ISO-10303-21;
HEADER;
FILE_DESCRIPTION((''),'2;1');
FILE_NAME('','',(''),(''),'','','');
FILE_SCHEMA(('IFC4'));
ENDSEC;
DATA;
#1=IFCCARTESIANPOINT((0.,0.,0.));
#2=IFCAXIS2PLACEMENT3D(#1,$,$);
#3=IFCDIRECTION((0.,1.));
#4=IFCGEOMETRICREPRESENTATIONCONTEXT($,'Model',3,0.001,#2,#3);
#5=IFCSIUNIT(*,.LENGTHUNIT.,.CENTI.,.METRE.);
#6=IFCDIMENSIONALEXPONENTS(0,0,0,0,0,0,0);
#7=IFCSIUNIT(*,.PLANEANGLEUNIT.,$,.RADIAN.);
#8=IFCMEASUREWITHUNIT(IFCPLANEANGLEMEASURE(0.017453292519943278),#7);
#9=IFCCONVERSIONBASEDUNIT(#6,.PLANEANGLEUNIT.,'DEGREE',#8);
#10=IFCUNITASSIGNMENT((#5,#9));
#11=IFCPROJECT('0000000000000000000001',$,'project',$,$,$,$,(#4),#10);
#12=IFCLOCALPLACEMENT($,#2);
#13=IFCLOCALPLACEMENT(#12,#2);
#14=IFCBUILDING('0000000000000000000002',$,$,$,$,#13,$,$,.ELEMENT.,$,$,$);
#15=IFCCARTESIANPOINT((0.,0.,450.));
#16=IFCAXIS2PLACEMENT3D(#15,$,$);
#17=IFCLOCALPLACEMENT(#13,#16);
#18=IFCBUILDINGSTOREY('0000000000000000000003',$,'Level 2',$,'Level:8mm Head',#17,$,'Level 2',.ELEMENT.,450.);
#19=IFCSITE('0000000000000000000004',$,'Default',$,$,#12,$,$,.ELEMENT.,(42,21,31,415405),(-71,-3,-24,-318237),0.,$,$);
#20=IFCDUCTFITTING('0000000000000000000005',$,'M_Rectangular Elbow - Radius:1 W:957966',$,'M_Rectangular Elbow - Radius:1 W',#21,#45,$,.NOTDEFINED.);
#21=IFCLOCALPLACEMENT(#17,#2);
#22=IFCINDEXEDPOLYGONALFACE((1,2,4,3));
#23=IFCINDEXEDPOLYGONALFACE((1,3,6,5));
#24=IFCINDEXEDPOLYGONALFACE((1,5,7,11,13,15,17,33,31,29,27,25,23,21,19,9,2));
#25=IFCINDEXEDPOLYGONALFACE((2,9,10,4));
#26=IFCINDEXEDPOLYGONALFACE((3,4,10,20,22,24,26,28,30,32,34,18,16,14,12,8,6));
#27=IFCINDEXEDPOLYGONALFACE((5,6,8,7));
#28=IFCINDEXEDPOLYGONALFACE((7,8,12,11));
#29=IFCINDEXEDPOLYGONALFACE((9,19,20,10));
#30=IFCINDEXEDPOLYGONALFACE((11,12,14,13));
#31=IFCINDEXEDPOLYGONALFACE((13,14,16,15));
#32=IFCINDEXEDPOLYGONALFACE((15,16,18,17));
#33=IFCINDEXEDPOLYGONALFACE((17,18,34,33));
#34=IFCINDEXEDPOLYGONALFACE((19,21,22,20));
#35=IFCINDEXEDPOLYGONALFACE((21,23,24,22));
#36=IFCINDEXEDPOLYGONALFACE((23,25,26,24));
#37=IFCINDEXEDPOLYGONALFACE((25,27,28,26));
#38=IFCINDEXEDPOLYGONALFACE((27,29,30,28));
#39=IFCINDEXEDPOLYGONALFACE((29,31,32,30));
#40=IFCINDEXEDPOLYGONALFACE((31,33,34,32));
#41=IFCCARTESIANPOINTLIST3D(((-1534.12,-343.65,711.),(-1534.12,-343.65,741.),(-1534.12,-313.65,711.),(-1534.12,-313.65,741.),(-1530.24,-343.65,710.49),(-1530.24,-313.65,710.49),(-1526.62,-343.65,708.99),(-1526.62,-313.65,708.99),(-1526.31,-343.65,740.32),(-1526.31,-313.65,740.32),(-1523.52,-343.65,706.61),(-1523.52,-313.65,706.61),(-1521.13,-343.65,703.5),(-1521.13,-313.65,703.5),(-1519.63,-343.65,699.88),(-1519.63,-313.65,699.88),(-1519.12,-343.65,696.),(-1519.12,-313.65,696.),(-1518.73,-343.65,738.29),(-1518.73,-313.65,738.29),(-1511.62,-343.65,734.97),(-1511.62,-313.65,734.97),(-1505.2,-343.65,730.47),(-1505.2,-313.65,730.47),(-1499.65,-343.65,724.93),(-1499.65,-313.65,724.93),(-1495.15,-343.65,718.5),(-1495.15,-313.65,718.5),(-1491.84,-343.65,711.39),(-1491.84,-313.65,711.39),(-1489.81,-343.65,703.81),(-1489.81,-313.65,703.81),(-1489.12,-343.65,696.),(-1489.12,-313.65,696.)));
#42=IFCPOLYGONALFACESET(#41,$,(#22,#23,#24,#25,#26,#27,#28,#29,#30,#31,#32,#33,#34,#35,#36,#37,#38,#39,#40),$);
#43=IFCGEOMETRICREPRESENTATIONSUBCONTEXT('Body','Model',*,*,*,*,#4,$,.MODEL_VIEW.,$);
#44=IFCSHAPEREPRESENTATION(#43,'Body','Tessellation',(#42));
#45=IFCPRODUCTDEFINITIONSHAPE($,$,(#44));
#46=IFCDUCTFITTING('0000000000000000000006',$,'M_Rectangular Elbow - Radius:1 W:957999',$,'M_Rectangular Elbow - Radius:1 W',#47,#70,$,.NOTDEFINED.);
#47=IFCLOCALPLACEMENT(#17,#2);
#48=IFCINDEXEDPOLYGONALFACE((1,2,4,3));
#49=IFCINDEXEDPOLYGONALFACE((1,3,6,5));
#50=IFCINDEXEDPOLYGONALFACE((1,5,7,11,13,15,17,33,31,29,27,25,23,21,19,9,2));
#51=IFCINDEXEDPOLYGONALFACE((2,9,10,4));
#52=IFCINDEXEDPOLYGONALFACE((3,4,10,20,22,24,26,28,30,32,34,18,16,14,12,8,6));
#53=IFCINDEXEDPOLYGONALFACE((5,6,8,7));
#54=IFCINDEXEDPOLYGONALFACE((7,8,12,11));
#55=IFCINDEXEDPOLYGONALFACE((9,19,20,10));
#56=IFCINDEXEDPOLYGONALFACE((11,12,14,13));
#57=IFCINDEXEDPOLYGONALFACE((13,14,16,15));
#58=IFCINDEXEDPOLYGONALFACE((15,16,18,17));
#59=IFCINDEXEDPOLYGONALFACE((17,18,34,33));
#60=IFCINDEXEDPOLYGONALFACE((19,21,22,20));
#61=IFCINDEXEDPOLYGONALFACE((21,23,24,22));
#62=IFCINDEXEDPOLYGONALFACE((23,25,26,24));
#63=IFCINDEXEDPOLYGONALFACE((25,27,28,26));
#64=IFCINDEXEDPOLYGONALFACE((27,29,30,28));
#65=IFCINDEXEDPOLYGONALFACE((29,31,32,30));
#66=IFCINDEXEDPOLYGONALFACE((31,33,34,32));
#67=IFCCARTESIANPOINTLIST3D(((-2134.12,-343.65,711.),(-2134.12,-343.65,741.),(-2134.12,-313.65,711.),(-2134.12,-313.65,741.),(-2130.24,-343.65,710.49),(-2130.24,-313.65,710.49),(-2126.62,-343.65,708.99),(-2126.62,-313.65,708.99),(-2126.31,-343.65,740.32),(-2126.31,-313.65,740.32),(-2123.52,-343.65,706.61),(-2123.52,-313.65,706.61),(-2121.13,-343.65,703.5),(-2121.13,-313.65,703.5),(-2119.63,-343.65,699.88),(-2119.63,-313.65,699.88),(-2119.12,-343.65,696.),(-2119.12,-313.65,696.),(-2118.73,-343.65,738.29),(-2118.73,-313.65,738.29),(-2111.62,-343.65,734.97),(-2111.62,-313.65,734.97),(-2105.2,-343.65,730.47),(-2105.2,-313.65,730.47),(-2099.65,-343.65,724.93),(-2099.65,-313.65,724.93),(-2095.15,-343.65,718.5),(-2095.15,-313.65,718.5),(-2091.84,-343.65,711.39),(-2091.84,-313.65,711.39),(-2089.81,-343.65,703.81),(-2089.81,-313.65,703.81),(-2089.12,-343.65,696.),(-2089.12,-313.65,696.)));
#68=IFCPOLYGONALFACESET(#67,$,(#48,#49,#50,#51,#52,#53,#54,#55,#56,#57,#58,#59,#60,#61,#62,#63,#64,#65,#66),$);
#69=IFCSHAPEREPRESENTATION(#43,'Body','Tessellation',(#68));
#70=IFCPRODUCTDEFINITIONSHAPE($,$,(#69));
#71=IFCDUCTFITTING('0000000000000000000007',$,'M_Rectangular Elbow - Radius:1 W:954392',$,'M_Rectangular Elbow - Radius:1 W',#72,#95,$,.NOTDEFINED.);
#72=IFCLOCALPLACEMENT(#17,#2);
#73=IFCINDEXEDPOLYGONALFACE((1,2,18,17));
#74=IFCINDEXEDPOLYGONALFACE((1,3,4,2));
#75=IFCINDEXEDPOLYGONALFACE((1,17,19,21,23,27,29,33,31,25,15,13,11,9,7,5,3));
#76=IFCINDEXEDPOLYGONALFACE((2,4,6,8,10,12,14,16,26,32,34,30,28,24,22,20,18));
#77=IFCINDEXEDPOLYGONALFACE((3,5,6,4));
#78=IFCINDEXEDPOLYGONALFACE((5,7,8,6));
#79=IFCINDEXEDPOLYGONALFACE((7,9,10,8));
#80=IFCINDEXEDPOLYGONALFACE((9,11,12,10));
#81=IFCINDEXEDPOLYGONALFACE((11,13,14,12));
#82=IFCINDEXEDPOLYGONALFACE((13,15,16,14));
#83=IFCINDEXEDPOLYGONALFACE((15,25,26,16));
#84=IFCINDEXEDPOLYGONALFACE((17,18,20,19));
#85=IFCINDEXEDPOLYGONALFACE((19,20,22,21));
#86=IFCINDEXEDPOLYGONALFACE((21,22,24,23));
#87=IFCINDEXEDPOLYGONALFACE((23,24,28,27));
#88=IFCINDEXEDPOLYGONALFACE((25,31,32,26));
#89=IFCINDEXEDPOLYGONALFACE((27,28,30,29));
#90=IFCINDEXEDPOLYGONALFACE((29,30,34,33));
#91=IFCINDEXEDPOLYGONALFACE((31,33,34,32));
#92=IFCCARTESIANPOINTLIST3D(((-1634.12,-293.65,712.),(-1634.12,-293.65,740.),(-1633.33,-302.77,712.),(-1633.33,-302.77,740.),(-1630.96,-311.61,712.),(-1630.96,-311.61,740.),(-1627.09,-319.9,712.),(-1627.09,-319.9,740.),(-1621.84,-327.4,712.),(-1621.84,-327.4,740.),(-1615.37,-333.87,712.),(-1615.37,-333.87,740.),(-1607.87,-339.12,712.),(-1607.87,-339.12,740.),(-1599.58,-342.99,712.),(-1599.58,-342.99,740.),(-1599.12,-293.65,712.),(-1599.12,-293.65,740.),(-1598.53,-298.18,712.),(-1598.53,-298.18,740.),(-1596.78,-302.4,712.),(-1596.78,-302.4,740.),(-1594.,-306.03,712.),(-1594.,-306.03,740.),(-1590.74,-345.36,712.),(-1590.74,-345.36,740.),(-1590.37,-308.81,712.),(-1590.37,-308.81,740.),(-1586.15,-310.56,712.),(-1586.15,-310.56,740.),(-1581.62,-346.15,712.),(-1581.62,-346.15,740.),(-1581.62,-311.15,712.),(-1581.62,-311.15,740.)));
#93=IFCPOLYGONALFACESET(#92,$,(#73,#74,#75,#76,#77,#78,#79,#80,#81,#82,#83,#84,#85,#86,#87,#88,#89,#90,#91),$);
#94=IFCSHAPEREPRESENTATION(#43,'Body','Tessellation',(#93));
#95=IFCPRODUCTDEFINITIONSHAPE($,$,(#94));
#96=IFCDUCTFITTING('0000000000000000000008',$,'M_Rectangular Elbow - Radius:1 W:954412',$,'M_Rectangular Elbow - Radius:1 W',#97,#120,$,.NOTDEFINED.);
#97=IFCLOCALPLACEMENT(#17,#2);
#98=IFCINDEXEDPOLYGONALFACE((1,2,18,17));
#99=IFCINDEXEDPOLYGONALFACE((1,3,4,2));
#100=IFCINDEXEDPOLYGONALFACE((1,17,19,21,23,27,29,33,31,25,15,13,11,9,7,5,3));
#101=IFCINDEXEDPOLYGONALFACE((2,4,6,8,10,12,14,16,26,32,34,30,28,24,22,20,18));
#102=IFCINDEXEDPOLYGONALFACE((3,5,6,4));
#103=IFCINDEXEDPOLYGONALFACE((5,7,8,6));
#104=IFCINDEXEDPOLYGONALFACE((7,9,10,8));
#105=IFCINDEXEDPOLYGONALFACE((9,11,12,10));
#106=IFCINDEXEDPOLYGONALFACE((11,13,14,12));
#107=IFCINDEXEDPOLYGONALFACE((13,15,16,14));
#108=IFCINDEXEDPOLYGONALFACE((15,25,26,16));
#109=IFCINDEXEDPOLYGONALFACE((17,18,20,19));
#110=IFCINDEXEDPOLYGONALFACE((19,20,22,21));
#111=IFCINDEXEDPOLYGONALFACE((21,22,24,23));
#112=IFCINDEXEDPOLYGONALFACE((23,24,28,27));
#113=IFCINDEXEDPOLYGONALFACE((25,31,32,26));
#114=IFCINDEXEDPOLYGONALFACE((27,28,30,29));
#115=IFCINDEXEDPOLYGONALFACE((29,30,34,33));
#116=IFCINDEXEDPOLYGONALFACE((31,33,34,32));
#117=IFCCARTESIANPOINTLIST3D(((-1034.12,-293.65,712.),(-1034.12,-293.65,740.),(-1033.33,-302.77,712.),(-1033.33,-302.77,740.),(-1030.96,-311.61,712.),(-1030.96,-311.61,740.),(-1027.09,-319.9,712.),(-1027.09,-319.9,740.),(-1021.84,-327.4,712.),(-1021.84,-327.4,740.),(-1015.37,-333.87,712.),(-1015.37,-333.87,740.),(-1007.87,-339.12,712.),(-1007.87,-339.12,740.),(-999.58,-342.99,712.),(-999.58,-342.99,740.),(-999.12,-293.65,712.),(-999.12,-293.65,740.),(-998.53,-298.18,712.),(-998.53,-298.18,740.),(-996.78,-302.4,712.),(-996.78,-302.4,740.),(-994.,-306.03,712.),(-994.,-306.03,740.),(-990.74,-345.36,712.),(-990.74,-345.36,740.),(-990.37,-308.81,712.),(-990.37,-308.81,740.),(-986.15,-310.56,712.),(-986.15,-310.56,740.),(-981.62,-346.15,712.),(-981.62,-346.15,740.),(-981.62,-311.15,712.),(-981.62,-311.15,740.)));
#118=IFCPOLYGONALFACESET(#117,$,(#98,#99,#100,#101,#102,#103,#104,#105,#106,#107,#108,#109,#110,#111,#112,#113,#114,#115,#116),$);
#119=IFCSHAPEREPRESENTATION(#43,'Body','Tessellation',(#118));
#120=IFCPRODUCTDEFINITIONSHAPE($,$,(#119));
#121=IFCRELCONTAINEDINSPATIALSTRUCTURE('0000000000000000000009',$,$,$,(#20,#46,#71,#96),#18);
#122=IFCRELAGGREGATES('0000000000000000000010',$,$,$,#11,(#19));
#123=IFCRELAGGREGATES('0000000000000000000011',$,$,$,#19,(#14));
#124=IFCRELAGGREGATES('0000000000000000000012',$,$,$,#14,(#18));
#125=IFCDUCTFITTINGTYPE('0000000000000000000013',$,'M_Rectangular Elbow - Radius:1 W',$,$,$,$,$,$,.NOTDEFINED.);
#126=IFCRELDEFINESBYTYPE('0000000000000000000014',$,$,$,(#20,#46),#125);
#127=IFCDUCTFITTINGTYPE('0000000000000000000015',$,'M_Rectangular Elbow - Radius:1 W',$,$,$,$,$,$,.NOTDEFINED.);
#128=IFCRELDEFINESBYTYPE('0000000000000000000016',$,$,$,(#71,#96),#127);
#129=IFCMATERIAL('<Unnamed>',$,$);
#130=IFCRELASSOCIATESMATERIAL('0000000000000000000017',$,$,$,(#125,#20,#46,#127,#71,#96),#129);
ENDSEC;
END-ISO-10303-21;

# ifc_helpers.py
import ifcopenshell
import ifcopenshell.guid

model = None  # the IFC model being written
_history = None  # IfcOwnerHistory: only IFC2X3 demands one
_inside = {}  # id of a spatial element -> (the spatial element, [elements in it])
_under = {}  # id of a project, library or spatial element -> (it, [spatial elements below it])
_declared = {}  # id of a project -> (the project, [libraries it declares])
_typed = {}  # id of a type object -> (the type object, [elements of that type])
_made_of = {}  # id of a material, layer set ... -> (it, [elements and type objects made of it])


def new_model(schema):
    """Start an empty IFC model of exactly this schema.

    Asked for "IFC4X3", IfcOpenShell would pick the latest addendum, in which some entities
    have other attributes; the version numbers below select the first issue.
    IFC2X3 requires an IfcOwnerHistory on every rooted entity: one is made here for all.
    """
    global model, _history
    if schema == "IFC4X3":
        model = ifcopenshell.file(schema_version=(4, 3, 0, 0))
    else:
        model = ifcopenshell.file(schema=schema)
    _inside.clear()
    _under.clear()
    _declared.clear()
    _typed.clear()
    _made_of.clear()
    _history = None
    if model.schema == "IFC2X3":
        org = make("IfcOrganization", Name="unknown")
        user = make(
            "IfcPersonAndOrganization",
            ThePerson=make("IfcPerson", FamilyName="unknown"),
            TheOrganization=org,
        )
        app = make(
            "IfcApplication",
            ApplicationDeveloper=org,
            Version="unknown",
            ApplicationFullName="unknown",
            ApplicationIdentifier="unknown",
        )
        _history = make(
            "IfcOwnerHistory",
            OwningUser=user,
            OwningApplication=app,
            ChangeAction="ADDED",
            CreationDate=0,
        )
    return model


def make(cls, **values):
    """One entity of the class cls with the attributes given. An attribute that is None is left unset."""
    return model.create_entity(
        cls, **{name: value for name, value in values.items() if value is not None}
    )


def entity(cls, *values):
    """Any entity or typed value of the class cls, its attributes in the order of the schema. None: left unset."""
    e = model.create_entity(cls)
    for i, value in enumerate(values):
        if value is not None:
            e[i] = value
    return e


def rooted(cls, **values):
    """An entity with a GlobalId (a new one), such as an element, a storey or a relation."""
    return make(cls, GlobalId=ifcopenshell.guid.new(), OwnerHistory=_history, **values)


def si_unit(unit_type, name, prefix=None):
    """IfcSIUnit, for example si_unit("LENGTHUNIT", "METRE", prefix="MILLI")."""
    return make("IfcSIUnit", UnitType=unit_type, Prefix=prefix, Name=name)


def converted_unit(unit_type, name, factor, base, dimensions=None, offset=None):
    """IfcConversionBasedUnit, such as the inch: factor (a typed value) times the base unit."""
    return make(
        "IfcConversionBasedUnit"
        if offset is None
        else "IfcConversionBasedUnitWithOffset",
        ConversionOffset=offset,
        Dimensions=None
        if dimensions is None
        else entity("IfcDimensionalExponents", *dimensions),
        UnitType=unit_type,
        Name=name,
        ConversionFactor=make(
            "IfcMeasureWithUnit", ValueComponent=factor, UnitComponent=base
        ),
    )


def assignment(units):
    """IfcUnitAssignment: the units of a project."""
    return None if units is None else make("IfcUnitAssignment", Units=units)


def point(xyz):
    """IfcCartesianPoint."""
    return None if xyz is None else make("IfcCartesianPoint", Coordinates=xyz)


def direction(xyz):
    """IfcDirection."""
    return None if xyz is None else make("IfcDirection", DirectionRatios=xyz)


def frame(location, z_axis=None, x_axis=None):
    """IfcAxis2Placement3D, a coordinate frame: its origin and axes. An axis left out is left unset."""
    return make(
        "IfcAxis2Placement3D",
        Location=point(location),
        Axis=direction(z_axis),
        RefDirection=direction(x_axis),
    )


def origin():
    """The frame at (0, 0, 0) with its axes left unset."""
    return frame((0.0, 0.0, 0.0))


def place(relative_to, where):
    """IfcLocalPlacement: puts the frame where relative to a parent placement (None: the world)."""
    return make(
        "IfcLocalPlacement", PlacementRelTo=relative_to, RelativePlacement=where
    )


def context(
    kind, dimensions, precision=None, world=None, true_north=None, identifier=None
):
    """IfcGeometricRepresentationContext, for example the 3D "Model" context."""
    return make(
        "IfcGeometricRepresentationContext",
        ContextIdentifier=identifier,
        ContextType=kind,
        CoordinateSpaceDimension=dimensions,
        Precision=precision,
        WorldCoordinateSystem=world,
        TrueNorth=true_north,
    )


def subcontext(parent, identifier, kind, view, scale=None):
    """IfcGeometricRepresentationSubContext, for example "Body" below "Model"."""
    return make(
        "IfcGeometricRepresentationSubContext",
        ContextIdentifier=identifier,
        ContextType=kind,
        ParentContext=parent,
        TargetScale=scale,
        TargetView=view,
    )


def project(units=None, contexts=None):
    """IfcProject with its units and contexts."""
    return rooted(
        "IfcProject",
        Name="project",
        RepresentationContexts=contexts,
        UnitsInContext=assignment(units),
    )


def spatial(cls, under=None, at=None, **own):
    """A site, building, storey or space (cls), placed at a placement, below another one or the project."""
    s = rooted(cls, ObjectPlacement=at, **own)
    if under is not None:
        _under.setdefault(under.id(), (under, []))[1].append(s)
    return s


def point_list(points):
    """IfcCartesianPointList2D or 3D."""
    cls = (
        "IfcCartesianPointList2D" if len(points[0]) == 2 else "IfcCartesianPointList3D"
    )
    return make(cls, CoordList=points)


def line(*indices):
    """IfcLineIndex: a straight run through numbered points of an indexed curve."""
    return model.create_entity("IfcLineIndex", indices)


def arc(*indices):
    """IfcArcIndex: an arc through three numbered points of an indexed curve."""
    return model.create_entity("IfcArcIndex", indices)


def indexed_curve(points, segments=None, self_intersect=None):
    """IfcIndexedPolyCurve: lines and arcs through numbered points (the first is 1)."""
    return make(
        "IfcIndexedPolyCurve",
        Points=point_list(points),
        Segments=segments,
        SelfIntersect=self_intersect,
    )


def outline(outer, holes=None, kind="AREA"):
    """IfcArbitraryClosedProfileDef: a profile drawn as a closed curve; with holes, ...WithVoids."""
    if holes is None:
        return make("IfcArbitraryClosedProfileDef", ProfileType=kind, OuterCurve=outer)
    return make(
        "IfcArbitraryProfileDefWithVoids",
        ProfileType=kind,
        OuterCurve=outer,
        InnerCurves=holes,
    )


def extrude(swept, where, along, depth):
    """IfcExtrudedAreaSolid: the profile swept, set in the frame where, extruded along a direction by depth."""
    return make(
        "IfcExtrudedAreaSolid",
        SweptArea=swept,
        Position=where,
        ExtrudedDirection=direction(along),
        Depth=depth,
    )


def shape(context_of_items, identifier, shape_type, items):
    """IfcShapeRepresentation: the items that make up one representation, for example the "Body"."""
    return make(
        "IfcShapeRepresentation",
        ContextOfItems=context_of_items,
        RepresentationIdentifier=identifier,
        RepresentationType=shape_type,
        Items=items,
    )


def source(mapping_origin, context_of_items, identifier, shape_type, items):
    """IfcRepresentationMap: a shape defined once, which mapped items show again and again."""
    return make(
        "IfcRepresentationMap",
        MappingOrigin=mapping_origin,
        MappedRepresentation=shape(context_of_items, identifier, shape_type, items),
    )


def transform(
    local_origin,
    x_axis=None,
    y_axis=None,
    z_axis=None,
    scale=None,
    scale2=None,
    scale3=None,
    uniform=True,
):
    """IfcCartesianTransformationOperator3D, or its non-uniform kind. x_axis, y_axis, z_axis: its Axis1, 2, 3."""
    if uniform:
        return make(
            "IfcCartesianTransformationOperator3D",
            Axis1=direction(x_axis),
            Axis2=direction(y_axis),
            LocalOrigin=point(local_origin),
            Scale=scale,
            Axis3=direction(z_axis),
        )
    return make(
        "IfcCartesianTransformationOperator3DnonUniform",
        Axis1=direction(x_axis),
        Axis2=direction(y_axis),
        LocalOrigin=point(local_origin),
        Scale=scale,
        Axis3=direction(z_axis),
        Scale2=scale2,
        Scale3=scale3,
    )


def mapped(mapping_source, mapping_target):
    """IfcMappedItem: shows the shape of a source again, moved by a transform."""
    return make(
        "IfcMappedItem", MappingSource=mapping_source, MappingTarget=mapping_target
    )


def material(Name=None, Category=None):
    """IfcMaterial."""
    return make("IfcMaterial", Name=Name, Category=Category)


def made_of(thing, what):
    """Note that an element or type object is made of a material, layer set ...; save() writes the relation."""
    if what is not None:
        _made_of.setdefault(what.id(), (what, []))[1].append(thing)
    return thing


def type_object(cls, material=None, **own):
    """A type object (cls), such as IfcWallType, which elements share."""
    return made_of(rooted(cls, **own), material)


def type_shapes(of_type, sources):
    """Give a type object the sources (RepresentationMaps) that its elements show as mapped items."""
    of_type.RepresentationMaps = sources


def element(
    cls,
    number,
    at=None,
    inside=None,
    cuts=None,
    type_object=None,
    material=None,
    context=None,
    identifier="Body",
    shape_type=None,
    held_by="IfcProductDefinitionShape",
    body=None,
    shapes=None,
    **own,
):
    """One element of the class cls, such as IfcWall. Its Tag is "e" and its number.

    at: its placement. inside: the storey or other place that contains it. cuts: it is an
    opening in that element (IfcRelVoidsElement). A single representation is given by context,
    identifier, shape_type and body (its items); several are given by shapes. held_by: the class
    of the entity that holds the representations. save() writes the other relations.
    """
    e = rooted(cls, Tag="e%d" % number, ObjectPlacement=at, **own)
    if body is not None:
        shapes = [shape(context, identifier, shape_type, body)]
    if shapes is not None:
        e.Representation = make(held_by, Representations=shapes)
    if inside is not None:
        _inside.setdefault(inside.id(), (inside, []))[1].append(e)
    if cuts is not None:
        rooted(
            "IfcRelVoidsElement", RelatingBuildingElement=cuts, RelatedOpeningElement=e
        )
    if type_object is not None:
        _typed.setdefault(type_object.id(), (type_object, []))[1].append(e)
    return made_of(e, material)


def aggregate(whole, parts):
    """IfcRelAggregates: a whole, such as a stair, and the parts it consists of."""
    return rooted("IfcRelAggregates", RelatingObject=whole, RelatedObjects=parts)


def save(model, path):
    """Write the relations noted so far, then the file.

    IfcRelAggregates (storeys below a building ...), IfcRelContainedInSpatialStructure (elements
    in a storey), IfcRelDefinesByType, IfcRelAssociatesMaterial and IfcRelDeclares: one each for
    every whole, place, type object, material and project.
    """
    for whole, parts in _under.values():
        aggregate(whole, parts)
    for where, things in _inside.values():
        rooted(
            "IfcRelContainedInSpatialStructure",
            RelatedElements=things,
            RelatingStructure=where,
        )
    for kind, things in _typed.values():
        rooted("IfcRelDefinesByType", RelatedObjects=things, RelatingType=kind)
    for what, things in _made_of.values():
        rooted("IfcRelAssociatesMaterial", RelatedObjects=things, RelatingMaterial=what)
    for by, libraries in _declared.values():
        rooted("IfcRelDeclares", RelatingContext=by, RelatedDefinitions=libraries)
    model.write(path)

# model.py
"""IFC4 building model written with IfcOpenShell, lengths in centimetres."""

from ifc_helpers import new_model, entity, si_unit, converted_unit, direction, frame, origin, place, context, subcontext, project, spatial, line, arc, indexed_curve, outline, extrude, source, transform, mapped, material, type_object, type_shapes, element, save


model = new_model("IFC4")

# Units and contexts
model_context = context("Model", 3, precision=0.001, world=origin(), true_north=direction((0.0, 1.0)))
body_context = subcontext(model_context, "Body", "Model", "MODEL_VIEW")
ifc_project = project(units=[si_unit("LENGTHUNIT", "METRE", prefix="CENTI"), converted_unit("PLANEANGLEUNIT", "DEGREE", entity("IfcPlaneAngleMeasure", 0.017453292519943278), si_unit("PLANEANGLEUNIT", "RADIAN"), dimensions=[0, 0, 0, 0, 0, 0, 0])], contexts=[model_context])

# Site, building, storey
site_placement = place(None, origin())
site = spatial("IfcSite", under=ifc_project, at=site_placement, Name="Default", CompositionType="ELEMENT", RefLatitude=(42, 21, 31, 415405), RefLongitude=(-71, -3, -24, -318237), RefElevation=0.0)
building_placement = place(site_placement, origin())
building = spatial("IfcBuilding", under=site, at=building_placement, CompositionType="ELEMENT")
storey_placement = place(building_placement, frame((0.0, 0.0, 450.0)))
storey = spatial("IfcBuildingStorey", under=building, at=storey_placement, Name="Level 2", ObjectType="Level:8mm Head", LongName="Level 2", CompositionType="ELEMENT", Elevation=450.0)

# Duct fittings
ifc_material = material(Name="<Unnamed>")
duct_fitting_type_1 = type_object("IfcDuctFittingType", Name="M_Rectangular Elbow - Radius:1 W", PredefinedType="NOTDEFINED", material=ifc_material)
shared_shape_1 = source(origin(), body_context, "Body", "SweptSolid", [
    extrude(outline(indexed_curve([(-30.0, -15.0), (0.0, -15.0), (4.39, -4.39), (15.0, 0.0), (15.0, 30.0), (-16.82, 16.82)], segments=[line(1, 2), arc(2, 3, 4), line(4, 5), arc(5, 6, 1)], self_intersect=False)), frame((-15.0, 15.0, -15.0), z_axis=(0.0, 0.0, 1.0), x_axis=(-1.0, 0.0, 0.0)), (0.0, 0.0, 1.0), 30.0),
])
type_shapes(duct_fitting_type_1, [shared_shape_1])
for number, where, z_axis, x_axis, name in (
    (1, (-1504.12, -328.65, 726.0), (0.0, 1.0, 0.0), (1.0, 0.0, 0.0), "M_Rectangular Elbow - Radius:1 W:957966"),
    (2, (-2104.12, -328.65, 726.0), (0.0, 1.0, 0.0), (1.0, 0.0, 0.0), "M_Rectangular Elbow - Radius:1 W:957999"),
):
    element("IfcDuctFitting", number, at=place(storey_placement, frame(where, z_axis=z_axis, x_axis=x_axis)), inside=storey, type_object=duct_fitting_type_1, material=ifc_material, Name=name, ObjectType="M_Rectangular Elbow - Radius:1 W", PredefinedType="NOTDEFINED", context=body_context, shape_type="MappedRepresentation", body=[
        mapped(shared_shape_1, transform((0.0, 0.0, 0.0), scale=1.0)),
    ])
duct_fitting_type_2 = type_object("IfcDuctFittingType", Name="M_Rectangular Elbow - Radius:1 W", PredefinedType="NOTDEFINED", material=ifc_material)
shared_shape_2 = source(origin(), body_context, "Body", "SweptSolid", [
    extrude(outline(indexed_curve([(-35.0, -17.5), (0.0, -17.5), (5.13, -5.13), (17.5, 0.0), (17.5, 35.0), (-19.62, 19.62)], segments=[line(1, 2), arc(2, 3, 4), line(4, 5), arc(5, 6, 1)], self_intersect=False)), frame((-17.5, 17.5, -14.0), z_axis=(0.0, 0.0, 1.0), x_axis=(-1.0, 0.0, 0.0)), (0.0, 0.0, 1.0), 28.0),
])
type_shapes(duct_fitting_type_2, [shared_shape_2])
for number, where, z_axis, x_axis, name in (
    (3, (-1616.62, -328.65, 726.0), (0.0, 0.0, 1.0), (0.0, -1.0, 0.0), "M_Rectangular Elbow - Radius:1 W:954392"),
    (4, (-1016.62, -328.65, 726.0), (0.0, 0.0, 1.0), (0.0, -1.0, 0.0), "M_Rectangular Elbow - Radius:1 W:954412"),
):
    element("IfcDuctFitting", number, at=place(storey_placement, frame(where, z_axis=z_axis, x_axis=x_axis)), inside=storey, type_object=duct_fitting_type_2, material=ifc_material, Name=name, ObjectType="M_Rectangular Elbow - Radius:1 W", PredefinedType="NOTDEFINED", context=body_context, shape_type="MappedRepresentation", body=[
        mapped(shared_shape_2, transform((0.0, 0.0, 0.0), scale=1.0)),
    ])

save(model, "model.ifc")
